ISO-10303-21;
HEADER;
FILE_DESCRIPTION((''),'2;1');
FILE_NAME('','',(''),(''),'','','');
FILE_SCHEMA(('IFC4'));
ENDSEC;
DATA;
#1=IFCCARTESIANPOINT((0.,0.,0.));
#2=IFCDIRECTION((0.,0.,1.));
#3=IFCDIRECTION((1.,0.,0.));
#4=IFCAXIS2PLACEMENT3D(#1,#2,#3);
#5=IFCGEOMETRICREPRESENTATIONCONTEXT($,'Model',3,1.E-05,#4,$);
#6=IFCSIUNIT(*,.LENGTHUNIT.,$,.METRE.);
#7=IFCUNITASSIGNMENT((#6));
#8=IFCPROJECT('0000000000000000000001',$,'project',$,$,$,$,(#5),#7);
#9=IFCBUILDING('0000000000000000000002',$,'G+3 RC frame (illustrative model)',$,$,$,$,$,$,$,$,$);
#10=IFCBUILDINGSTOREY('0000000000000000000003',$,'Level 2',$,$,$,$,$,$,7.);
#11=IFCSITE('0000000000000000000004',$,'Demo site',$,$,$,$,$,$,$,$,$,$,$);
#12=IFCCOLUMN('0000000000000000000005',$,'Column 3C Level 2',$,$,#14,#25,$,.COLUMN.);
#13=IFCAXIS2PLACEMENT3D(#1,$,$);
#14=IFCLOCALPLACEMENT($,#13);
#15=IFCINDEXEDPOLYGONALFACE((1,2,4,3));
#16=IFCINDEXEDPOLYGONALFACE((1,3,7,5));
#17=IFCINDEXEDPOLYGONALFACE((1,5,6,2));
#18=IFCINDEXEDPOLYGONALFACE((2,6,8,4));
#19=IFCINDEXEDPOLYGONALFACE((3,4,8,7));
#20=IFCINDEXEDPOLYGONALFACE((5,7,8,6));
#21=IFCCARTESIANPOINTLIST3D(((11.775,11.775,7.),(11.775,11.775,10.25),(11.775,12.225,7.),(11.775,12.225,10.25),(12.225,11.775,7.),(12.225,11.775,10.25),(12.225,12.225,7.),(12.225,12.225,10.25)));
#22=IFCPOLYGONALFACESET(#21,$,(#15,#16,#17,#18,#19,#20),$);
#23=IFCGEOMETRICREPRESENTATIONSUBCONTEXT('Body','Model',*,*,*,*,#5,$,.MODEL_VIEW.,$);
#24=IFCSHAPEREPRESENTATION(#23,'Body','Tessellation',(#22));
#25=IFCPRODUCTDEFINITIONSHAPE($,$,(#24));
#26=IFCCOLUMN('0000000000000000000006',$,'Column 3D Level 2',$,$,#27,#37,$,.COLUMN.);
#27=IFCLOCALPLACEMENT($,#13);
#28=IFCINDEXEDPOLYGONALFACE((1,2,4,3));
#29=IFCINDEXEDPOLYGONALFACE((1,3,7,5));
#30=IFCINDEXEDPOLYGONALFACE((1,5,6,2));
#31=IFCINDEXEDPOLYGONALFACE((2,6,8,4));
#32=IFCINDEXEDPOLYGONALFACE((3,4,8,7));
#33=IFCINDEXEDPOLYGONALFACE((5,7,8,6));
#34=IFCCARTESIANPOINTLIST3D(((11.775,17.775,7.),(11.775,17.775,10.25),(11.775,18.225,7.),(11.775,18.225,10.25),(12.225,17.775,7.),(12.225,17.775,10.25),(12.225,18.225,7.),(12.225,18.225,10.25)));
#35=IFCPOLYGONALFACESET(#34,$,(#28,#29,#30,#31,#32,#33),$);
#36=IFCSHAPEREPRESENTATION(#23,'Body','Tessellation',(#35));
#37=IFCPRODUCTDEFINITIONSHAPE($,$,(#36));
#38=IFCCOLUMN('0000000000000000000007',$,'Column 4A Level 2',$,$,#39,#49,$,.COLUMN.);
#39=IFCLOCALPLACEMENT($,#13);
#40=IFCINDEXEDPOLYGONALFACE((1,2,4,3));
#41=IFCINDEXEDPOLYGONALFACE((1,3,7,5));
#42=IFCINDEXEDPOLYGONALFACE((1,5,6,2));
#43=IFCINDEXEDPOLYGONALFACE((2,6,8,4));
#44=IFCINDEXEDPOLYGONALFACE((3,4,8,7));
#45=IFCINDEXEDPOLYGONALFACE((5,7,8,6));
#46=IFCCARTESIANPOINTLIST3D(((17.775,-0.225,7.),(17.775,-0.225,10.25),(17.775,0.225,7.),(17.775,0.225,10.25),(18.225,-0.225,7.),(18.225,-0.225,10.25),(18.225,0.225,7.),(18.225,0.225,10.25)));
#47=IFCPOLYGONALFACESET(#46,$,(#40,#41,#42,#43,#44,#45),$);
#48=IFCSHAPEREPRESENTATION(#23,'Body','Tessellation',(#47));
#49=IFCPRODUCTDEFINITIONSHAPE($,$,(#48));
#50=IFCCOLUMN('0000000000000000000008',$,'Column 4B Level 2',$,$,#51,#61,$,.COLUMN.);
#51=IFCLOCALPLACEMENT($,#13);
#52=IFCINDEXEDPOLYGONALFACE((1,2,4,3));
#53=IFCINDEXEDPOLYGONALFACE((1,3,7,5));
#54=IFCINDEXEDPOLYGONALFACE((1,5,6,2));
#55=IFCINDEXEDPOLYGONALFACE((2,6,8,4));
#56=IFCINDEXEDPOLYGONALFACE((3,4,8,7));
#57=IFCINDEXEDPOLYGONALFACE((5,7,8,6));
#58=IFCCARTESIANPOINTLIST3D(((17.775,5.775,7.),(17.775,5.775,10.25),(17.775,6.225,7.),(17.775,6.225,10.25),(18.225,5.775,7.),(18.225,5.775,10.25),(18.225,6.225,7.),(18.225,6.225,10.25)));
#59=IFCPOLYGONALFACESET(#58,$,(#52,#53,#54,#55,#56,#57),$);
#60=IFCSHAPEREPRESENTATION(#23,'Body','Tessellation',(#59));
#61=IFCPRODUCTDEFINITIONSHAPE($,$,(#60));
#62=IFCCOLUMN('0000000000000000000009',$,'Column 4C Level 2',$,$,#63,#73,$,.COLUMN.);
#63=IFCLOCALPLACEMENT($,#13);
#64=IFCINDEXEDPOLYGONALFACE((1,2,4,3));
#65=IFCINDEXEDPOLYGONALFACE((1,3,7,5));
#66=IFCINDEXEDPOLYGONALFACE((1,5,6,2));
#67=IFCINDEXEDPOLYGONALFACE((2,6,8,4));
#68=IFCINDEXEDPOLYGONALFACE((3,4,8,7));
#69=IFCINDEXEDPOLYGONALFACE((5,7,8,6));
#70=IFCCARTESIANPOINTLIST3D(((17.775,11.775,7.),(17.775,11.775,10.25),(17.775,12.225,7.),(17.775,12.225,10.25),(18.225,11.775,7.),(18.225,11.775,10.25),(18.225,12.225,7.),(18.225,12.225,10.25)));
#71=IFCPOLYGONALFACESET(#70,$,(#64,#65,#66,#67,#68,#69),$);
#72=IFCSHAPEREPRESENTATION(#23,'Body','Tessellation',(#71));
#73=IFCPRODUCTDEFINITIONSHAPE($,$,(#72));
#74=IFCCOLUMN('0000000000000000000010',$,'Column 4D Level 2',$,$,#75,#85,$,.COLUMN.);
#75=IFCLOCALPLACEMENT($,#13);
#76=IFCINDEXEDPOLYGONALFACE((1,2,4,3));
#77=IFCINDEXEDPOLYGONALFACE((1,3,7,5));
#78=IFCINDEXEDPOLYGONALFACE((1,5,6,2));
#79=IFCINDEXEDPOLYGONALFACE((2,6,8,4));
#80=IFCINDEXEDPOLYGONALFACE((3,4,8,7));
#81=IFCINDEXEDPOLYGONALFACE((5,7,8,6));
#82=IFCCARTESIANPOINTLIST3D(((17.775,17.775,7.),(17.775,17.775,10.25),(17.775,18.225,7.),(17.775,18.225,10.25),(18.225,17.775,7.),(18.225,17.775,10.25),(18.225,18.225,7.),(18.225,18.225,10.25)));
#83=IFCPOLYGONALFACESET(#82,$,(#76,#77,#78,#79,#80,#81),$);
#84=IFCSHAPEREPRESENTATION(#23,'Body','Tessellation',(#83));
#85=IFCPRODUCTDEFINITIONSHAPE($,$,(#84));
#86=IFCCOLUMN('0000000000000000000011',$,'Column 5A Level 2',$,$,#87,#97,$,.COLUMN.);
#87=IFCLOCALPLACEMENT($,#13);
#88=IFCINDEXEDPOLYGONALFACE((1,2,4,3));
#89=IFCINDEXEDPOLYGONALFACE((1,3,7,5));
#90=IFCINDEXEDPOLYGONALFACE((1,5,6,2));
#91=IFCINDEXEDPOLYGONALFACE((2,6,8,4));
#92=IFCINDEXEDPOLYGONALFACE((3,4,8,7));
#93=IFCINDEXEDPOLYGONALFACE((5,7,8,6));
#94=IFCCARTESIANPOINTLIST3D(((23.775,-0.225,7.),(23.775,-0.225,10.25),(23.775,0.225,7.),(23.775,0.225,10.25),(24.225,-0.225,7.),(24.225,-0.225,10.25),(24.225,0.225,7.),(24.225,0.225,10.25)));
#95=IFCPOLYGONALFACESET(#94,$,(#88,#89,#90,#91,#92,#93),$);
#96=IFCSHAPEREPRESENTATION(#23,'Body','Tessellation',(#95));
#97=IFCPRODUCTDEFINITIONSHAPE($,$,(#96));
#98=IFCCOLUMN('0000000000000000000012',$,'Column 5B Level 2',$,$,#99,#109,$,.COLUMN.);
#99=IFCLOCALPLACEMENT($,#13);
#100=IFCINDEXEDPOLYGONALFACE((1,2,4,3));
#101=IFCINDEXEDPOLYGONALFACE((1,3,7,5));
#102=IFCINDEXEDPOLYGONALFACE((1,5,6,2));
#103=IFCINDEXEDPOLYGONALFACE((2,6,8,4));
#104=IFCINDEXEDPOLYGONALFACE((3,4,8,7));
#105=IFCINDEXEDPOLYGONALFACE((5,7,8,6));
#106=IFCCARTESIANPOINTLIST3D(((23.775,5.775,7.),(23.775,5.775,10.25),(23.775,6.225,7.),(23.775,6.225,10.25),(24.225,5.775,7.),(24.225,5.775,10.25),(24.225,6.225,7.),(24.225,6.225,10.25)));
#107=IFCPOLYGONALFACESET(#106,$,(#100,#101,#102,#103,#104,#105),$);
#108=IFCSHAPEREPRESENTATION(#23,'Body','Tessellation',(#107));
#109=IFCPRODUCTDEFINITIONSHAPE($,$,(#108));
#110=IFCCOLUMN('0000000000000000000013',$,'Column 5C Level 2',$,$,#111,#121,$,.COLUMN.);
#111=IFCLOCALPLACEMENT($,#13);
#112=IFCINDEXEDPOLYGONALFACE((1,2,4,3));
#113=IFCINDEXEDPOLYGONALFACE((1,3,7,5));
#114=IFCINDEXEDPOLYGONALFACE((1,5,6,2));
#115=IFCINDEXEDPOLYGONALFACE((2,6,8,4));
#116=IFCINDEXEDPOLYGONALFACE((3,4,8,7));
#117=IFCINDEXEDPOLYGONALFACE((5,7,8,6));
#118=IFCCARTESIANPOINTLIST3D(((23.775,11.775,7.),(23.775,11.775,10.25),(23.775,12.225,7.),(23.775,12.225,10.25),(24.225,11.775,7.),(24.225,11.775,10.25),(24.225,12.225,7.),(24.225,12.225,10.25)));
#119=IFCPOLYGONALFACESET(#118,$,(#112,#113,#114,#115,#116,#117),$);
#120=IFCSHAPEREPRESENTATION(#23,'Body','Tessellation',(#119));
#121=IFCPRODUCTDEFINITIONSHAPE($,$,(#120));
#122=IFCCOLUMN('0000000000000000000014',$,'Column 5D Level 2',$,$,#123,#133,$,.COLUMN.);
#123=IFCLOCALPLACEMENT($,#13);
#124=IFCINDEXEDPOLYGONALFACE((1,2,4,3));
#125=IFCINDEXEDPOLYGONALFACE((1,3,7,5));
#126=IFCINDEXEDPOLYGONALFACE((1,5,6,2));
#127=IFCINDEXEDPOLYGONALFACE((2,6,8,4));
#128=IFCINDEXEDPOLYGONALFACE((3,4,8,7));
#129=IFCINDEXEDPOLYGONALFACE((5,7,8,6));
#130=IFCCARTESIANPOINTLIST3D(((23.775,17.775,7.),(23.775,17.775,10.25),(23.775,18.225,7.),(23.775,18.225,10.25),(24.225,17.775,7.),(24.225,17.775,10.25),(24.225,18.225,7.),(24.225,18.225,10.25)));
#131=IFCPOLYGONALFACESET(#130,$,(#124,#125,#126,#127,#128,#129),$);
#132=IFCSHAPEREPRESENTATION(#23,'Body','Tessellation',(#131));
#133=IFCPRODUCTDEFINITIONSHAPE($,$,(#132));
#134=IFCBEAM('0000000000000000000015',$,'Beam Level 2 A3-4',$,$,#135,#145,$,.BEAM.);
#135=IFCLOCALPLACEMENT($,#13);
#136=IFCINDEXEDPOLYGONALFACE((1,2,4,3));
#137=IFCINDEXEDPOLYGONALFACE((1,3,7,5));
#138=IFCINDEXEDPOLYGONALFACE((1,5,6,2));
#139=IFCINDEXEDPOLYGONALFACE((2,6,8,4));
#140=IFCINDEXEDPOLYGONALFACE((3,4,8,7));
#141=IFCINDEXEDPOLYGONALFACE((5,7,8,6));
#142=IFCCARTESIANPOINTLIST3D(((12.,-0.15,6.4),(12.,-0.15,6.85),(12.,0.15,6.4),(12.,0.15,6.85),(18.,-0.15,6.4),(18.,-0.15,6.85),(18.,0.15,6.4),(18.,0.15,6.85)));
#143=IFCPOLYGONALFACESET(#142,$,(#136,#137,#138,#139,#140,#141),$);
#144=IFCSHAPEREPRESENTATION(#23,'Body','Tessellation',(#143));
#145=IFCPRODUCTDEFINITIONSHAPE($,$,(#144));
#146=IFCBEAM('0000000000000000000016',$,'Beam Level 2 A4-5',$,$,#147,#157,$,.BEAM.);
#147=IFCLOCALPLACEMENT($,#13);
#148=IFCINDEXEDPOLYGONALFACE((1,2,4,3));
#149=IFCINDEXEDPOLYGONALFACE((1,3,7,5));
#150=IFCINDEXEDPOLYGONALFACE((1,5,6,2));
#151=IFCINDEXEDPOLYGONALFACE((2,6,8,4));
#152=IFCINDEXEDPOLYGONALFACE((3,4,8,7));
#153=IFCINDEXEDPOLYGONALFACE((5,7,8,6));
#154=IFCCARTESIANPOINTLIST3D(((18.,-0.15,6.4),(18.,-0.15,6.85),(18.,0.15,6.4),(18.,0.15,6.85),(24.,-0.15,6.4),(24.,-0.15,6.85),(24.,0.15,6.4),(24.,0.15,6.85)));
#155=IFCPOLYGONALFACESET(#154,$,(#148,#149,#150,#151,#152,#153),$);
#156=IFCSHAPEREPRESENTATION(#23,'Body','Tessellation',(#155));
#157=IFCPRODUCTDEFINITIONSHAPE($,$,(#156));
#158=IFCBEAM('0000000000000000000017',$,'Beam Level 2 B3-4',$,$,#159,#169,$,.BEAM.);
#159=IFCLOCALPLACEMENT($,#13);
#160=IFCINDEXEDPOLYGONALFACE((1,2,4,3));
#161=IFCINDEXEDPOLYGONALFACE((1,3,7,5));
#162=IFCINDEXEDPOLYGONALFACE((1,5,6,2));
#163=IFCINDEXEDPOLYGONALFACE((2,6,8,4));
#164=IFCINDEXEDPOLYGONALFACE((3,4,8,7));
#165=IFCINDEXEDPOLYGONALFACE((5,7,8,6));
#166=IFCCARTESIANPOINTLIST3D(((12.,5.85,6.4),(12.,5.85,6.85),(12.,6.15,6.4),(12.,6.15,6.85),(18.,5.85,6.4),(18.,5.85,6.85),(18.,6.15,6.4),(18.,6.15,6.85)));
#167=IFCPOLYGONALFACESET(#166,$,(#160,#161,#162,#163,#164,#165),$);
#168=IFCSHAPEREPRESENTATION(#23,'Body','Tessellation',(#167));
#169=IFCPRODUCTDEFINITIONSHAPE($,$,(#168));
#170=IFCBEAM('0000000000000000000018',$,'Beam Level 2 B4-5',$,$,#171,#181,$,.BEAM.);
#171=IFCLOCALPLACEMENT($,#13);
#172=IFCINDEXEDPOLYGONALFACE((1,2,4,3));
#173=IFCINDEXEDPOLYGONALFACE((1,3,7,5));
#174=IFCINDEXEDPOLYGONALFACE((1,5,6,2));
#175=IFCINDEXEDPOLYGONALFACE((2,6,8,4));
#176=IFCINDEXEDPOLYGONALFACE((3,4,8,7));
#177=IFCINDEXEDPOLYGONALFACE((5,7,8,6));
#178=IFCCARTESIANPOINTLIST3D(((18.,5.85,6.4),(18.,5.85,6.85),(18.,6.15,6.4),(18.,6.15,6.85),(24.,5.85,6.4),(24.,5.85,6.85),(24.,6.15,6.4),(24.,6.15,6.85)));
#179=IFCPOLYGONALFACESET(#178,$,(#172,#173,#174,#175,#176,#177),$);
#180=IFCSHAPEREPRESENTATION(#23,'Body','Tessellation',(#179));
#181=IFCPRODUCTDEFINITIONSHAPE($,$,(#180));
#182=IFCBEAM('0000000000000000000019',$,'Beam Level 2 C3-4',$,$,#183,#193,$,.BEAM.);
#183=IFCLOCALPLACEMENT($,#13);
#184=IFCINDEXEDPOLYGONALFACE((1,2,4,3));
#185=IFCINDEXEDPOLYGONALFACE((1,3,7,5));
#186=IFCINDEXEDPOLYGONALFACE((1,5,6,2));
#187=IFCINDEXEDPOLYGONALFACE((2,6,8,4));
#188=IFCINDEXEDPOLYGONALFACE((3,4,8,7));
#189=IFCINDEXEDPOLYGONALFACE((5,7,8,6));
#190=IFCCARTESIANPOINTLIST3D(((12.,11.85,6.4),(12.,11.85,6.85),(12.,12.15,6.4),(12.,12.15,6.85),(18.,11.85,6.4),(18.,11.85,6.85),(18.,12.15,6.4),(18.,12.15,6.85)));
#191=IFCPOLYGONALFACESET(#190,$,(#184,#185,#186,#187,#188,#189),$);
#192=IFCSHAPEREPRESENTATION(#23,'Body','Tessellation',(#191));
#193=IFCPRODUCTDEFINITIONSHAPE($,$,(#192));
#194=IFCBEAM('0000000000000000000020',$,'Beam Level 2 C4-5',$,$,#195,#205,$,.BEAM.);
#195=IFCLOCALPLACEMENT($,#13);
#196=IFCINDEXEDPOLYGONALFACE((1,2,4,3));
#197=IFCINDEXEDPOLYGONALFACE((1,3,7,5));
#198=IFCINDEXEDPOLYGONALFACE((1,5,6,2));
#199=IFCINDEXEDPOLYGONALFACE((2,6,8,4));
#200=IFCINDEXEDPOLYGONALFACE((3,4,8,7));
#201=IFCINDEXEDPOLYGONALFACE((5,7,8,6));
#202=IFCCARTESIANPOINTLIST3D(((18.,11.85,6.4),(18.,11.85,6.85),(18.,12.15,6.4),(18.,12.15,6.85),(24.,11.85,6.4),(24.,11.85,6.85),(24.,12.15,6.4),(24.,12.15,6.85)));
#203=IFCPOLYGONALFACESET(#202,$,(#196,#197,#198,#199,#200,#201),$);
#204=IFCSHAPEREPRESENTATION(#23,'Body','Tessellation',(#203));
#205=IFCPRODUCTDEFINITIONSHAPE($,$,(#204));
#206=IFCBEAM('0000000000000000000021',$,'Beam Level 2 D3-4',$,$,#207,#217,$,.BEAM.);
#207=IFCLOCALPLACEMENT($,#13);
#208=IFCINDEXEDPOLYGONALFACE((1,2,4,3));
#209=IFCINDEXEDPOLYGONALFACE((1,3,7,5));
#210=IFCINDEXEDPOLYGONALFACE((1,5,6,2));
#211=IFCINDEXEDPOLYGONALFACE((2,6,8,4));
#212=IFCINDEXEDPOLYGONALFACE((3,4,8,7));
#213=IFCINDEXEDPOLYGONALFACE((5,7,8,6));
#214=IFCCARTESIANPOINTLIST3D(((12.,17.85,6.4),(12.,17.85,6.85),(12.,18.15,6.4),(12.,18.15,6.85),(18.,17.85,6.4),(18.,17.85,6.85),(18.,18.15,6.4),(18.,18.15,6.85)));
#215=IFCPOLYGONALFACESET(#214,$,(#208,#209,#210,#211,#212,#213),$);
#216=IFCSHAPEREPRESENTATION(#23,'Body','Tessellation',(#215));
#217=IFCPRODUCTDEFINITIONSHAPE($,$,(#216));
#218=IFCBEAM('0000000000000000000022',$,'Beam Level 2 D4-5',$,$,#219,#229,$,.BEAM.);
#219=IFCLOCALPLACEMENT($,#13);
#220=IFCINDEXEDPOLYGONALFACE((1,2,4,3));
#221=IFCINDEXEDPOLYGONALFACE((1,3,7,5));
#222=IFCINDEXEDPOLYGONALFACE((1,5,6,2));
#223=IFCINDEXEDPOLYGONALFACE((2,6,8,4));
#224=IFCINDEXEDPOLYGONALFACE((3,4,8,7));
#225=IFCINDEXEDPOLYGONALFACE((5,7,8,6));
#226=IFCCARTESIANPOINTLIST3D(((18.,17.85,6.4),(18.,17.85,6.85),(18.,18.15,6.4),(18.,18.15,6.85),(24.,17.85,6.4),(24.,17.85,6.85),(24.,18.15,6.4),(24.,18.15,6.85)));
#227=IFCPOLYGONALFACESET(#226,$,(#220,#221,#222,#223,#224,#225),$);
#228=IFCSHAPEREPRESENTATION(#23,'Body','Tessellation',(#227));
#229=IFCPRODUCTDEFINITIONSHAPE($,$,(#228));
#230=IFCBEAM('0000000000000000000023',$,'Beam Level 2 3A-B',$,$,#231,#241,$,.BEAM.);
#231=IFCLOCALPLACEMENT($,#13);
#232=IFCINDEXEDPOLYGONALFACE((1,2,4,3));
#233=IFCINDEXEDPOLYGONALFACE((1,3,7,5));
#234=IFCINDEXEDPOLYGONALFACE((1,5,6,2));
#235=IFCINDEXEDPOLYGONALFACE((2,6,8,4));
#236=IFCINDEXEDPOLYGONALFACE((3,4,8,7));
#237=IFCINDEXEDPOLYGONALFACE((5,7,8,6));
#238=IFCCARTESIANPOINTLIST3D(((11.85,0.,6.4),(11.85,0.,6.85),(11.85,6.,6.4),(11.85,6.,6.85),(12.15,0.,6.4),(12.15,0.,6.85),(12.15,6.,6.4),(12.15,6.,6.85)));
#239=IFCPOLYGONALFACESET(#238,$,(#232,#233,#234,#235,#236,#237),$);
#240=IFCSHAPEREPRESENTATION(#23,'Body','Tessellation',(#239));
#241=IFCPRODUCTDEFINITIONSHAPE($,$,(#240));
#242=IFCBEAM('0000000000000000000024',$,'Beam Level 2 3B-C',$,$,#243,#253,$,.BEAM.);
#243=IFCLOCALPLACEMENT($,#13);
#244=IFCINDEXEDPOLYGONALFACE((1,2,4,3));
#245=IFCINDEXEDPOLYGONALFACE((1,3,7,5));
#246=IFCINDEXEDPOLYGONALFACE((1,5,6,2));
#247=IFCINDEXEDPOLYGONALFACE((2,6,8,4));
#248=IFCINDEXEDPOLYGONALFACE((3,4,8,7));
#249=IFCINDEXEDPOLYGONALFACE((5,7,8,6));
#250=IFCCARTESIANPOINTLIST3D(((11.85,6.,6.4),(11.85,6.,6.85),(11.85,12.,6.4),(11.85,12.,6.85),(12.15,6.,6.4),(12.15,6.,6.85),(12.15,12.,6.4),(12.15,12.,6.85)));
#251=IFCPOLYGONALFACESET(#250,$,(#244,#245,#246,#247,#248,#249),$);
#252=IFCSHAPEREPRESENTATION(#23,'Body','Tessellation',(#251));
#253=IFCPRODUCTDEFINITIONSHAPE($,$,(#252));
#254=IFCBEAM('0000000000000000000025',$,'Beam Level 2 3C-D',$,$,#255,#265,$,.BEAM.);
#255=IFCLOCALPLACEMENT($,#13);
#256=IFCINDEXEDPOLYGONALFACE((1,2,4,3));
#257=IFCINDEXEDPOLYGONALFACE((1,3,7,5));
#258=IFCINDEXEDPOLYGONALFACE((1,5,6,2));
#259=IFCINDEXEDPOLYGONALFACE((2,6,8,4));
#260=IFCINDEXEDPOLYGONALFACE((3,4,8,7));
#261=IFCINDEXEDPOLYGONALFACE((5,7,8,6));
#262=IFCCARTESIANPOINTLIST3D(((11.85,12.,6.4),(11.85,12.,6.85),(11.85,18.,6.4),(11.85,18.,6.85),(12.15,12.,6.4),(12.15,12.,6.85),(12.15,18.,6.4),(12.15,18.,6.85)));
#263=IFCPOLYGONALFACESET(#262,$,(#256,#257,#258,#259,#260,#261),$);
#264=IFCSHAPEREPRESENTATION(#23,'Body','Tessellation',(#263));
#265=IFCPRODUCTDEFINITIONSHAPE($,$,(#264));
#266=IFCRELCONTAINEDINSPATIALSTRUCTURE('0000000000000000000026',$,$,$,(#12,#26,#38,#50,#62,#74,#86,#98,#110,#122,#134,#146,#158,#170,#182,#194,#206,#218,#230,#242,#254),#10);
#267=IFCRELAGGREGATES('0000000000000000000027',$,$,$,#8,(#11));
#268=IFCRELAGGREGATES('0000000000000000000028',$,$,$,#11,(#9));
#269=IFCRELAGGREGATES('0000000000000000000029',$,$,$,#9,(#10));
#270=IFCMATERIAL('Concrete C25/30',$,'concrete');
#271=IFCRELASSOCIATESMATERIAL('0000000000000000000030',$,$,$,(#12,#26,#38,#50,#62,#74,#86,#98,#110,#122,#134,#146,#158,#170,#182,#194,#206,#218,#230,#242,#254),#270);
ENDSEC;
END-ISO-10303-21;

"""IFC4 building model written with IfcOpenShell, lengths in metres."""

from ifc_helpers import new_model, si_unit, frame, frame_2d, origin, origin_with_axes, place, context, subcontext, project, spatial, rectangle, extrude, material, element, save


model = new_model("IFC4")

# Units and contexts
model_context = context("Model", 3, precision=1e-05, world=origin_with_axes())
body_context = subcontext(model_context, "Body", "Model", "MODEL_VIEW")
ifc_project = project(units=[si_unit("LENGTHUNIT", "METRE")], contexts=[model_context])

# Site, building, storey
site = spatial("IfcSite", under=ifc_project, Name="Demo site")
building = spatial("IfcBuilding", under=site, Name="G+3 RC frame (illustrative model)")
storey = spatial("IfcBuildingStorey", under=building, Name="Level 2", Elevation=7.0)

# Columns
ifc_material_1 = material(Name="Concrete C25/30", Category="concrete")
for number, where, z_axis, x_axis, name in (
    (1, (11.775, 11.775, 7.0), (0.0, 0.0, 1.0), (1.0, 0.0, 0.0), "Column 3C Level 2"),
    (2, (11.775, 17.775, 7.0), (0.0, 0.0, 1.0), (1.0, 0.0, 0.0), "Column 3D Level 2"),
    (3, (17.775, -0.225, 7.0), (0.0, 0.0, 1.0), (1.0, 0.0, 0.0), "Column 4A Level 2"),
    (4, (17.775, 5.775, 7.0), (0.0, 0.0, 1.0), (1.0, 0.0, 0.0), "Column 4B Level 2"),
    (5, (17.775, 11.775, 7.0), (0.0, 0.0, 1.0), (1.0, 0.0, 0.0), "Column 4C Level 2"),
    (6, (17.775, 17.775, 7.0), (0.0, 0.0, 1.0), (1.0, 0.0, 0.0), "Column 4D Level 2"),
    (7, (23.775, -0.225, 7.0), (0.0, 0.0, 1.0), (1.0, 0.0, 0.0), "Column 5A Level 2"),
    (8, (23.775, 5.775, 7.0), (0.0, 0.0, 1.0), (1.0, 0.0, 0.0), "Column 5B Level 2"),
    (9, (23.775, 11.775, 7.0), (0.0, 0.0, 1.0), (1.0, 0.0, 0.0), "Column 5C Level 2"),
    (10, (23.775, 17.775, 7.0), (0.0, 0.0, 1.0), (1.0, 0.0, 0.0), "Column 5D Level 2"),
):
    element("IfcColumn", number, at=place(None, frame(where, z_axis=z_axis, x_axis=x_axis)), inside=storey, material=ifc_material_1, Name=name, PredefinedType="COLUMN", context=body_context, shape_type="SweptSolid", body=[
        extrude(rectangle(XDim=0.45, YDim=0.45, at=frame_2d((0.225, 0.225))), origin(), (0.0, 0.0, 1.0), 3.25),
    ])

# Beams
for number, where, z_axis, x_axis, name in (
    (11, (12.0, -0.15, 6.4), (0.0, 0.0, 1.0), (1.0, 0.0, 0.0), "Beam Level 2 A3-4"),
    (12, (18.0, -0.15, 6.4), (0.0, 0.0, 1.0), (1.0, 0.0, 0.0), "Beam Level 2 A4-5"),
    (13, (12.0, 5.85, 6.4), (0.0, 0.0, 1.0), (1.0, 0.0, 0.0), "Beam Level 2 B3-4"),
    (14, (18.0, 5.85, 6.4), (0.0, 0.0, 1.0), (1.0, 0.0, 0.0), "Beam Level 2 B4-5"),
    (15, (12.0, 11.85, 6.4), (0.0, 0.0, 1.0), (1.0, 0.0, 0.0), "Beam Level 2 C3-4"),
    (16, (18.0, 11.85, 6.4), (0.0, 0.0, 1.0), (1.0, 0.0, 0.0), "Beam Level 2 C4-5"),
    (17, (12.0, 17.85, 6.4), (0.0, 0.0, 1.0), (1.0, 0.0, 0.0), "Beam Level 2 D3-4"),
    (18, (18.0, 17.85, 6.4), (0.0, 0.0, 1.0), (1.0, 0.0, 0.0), "Beam Level 2 D4-5"),
):
    element("IfcBeam", number, at=place(None, frame(where, z_axis=z_axis, x_axis=x_axis)), inside=storey, material=ifc_material_1, Name=name, PredefinedType="BEAM", context=body_context, shape_type="SweptSolid", body=[
        extrude(rectangle(XDim=6.0, YDim=0.3, at=frame_2d((3.0, 0.15))), origin(), (0.0, 0.0, 1.0), 0.45),
    ])
for number, where, z_axis, x_axis, name in (
    (19, (11.85, 0.0, 6.4), (0.0, 0.0, 1.0), (1.0, 0.0, 0.0), "Beam Level 2 3A-B"),
    (20, (11.85, 6.0, 6.4), (0.0, 0.0, 1.0), (1.0, 0.0, 0.0), "Beam Level 2 3B-C"),
    (21, (11.85, 12.0, 6.4), (0.0, 0.0, 1.0), (1.0, 0.0, 0.0), "Beam Level 2 3C-D"),
):
    element("IfcBeam", number, at=place(None, frame(where, z_axis=z_axis, x_axis=x_axis)), inside=storey, material=ifc_material_1, Name=name, PredefinedType="BEAM", context=body_context, shape_type="SweptSolid", body=[
        extrude(rectangle(XDim=0.3, YDim=6.0, at=frame_2d((0.15, 3.0))), origin(), (0.0, 0.0, 1.0), 0.45),
    ])

save(model, "model.ifc")
